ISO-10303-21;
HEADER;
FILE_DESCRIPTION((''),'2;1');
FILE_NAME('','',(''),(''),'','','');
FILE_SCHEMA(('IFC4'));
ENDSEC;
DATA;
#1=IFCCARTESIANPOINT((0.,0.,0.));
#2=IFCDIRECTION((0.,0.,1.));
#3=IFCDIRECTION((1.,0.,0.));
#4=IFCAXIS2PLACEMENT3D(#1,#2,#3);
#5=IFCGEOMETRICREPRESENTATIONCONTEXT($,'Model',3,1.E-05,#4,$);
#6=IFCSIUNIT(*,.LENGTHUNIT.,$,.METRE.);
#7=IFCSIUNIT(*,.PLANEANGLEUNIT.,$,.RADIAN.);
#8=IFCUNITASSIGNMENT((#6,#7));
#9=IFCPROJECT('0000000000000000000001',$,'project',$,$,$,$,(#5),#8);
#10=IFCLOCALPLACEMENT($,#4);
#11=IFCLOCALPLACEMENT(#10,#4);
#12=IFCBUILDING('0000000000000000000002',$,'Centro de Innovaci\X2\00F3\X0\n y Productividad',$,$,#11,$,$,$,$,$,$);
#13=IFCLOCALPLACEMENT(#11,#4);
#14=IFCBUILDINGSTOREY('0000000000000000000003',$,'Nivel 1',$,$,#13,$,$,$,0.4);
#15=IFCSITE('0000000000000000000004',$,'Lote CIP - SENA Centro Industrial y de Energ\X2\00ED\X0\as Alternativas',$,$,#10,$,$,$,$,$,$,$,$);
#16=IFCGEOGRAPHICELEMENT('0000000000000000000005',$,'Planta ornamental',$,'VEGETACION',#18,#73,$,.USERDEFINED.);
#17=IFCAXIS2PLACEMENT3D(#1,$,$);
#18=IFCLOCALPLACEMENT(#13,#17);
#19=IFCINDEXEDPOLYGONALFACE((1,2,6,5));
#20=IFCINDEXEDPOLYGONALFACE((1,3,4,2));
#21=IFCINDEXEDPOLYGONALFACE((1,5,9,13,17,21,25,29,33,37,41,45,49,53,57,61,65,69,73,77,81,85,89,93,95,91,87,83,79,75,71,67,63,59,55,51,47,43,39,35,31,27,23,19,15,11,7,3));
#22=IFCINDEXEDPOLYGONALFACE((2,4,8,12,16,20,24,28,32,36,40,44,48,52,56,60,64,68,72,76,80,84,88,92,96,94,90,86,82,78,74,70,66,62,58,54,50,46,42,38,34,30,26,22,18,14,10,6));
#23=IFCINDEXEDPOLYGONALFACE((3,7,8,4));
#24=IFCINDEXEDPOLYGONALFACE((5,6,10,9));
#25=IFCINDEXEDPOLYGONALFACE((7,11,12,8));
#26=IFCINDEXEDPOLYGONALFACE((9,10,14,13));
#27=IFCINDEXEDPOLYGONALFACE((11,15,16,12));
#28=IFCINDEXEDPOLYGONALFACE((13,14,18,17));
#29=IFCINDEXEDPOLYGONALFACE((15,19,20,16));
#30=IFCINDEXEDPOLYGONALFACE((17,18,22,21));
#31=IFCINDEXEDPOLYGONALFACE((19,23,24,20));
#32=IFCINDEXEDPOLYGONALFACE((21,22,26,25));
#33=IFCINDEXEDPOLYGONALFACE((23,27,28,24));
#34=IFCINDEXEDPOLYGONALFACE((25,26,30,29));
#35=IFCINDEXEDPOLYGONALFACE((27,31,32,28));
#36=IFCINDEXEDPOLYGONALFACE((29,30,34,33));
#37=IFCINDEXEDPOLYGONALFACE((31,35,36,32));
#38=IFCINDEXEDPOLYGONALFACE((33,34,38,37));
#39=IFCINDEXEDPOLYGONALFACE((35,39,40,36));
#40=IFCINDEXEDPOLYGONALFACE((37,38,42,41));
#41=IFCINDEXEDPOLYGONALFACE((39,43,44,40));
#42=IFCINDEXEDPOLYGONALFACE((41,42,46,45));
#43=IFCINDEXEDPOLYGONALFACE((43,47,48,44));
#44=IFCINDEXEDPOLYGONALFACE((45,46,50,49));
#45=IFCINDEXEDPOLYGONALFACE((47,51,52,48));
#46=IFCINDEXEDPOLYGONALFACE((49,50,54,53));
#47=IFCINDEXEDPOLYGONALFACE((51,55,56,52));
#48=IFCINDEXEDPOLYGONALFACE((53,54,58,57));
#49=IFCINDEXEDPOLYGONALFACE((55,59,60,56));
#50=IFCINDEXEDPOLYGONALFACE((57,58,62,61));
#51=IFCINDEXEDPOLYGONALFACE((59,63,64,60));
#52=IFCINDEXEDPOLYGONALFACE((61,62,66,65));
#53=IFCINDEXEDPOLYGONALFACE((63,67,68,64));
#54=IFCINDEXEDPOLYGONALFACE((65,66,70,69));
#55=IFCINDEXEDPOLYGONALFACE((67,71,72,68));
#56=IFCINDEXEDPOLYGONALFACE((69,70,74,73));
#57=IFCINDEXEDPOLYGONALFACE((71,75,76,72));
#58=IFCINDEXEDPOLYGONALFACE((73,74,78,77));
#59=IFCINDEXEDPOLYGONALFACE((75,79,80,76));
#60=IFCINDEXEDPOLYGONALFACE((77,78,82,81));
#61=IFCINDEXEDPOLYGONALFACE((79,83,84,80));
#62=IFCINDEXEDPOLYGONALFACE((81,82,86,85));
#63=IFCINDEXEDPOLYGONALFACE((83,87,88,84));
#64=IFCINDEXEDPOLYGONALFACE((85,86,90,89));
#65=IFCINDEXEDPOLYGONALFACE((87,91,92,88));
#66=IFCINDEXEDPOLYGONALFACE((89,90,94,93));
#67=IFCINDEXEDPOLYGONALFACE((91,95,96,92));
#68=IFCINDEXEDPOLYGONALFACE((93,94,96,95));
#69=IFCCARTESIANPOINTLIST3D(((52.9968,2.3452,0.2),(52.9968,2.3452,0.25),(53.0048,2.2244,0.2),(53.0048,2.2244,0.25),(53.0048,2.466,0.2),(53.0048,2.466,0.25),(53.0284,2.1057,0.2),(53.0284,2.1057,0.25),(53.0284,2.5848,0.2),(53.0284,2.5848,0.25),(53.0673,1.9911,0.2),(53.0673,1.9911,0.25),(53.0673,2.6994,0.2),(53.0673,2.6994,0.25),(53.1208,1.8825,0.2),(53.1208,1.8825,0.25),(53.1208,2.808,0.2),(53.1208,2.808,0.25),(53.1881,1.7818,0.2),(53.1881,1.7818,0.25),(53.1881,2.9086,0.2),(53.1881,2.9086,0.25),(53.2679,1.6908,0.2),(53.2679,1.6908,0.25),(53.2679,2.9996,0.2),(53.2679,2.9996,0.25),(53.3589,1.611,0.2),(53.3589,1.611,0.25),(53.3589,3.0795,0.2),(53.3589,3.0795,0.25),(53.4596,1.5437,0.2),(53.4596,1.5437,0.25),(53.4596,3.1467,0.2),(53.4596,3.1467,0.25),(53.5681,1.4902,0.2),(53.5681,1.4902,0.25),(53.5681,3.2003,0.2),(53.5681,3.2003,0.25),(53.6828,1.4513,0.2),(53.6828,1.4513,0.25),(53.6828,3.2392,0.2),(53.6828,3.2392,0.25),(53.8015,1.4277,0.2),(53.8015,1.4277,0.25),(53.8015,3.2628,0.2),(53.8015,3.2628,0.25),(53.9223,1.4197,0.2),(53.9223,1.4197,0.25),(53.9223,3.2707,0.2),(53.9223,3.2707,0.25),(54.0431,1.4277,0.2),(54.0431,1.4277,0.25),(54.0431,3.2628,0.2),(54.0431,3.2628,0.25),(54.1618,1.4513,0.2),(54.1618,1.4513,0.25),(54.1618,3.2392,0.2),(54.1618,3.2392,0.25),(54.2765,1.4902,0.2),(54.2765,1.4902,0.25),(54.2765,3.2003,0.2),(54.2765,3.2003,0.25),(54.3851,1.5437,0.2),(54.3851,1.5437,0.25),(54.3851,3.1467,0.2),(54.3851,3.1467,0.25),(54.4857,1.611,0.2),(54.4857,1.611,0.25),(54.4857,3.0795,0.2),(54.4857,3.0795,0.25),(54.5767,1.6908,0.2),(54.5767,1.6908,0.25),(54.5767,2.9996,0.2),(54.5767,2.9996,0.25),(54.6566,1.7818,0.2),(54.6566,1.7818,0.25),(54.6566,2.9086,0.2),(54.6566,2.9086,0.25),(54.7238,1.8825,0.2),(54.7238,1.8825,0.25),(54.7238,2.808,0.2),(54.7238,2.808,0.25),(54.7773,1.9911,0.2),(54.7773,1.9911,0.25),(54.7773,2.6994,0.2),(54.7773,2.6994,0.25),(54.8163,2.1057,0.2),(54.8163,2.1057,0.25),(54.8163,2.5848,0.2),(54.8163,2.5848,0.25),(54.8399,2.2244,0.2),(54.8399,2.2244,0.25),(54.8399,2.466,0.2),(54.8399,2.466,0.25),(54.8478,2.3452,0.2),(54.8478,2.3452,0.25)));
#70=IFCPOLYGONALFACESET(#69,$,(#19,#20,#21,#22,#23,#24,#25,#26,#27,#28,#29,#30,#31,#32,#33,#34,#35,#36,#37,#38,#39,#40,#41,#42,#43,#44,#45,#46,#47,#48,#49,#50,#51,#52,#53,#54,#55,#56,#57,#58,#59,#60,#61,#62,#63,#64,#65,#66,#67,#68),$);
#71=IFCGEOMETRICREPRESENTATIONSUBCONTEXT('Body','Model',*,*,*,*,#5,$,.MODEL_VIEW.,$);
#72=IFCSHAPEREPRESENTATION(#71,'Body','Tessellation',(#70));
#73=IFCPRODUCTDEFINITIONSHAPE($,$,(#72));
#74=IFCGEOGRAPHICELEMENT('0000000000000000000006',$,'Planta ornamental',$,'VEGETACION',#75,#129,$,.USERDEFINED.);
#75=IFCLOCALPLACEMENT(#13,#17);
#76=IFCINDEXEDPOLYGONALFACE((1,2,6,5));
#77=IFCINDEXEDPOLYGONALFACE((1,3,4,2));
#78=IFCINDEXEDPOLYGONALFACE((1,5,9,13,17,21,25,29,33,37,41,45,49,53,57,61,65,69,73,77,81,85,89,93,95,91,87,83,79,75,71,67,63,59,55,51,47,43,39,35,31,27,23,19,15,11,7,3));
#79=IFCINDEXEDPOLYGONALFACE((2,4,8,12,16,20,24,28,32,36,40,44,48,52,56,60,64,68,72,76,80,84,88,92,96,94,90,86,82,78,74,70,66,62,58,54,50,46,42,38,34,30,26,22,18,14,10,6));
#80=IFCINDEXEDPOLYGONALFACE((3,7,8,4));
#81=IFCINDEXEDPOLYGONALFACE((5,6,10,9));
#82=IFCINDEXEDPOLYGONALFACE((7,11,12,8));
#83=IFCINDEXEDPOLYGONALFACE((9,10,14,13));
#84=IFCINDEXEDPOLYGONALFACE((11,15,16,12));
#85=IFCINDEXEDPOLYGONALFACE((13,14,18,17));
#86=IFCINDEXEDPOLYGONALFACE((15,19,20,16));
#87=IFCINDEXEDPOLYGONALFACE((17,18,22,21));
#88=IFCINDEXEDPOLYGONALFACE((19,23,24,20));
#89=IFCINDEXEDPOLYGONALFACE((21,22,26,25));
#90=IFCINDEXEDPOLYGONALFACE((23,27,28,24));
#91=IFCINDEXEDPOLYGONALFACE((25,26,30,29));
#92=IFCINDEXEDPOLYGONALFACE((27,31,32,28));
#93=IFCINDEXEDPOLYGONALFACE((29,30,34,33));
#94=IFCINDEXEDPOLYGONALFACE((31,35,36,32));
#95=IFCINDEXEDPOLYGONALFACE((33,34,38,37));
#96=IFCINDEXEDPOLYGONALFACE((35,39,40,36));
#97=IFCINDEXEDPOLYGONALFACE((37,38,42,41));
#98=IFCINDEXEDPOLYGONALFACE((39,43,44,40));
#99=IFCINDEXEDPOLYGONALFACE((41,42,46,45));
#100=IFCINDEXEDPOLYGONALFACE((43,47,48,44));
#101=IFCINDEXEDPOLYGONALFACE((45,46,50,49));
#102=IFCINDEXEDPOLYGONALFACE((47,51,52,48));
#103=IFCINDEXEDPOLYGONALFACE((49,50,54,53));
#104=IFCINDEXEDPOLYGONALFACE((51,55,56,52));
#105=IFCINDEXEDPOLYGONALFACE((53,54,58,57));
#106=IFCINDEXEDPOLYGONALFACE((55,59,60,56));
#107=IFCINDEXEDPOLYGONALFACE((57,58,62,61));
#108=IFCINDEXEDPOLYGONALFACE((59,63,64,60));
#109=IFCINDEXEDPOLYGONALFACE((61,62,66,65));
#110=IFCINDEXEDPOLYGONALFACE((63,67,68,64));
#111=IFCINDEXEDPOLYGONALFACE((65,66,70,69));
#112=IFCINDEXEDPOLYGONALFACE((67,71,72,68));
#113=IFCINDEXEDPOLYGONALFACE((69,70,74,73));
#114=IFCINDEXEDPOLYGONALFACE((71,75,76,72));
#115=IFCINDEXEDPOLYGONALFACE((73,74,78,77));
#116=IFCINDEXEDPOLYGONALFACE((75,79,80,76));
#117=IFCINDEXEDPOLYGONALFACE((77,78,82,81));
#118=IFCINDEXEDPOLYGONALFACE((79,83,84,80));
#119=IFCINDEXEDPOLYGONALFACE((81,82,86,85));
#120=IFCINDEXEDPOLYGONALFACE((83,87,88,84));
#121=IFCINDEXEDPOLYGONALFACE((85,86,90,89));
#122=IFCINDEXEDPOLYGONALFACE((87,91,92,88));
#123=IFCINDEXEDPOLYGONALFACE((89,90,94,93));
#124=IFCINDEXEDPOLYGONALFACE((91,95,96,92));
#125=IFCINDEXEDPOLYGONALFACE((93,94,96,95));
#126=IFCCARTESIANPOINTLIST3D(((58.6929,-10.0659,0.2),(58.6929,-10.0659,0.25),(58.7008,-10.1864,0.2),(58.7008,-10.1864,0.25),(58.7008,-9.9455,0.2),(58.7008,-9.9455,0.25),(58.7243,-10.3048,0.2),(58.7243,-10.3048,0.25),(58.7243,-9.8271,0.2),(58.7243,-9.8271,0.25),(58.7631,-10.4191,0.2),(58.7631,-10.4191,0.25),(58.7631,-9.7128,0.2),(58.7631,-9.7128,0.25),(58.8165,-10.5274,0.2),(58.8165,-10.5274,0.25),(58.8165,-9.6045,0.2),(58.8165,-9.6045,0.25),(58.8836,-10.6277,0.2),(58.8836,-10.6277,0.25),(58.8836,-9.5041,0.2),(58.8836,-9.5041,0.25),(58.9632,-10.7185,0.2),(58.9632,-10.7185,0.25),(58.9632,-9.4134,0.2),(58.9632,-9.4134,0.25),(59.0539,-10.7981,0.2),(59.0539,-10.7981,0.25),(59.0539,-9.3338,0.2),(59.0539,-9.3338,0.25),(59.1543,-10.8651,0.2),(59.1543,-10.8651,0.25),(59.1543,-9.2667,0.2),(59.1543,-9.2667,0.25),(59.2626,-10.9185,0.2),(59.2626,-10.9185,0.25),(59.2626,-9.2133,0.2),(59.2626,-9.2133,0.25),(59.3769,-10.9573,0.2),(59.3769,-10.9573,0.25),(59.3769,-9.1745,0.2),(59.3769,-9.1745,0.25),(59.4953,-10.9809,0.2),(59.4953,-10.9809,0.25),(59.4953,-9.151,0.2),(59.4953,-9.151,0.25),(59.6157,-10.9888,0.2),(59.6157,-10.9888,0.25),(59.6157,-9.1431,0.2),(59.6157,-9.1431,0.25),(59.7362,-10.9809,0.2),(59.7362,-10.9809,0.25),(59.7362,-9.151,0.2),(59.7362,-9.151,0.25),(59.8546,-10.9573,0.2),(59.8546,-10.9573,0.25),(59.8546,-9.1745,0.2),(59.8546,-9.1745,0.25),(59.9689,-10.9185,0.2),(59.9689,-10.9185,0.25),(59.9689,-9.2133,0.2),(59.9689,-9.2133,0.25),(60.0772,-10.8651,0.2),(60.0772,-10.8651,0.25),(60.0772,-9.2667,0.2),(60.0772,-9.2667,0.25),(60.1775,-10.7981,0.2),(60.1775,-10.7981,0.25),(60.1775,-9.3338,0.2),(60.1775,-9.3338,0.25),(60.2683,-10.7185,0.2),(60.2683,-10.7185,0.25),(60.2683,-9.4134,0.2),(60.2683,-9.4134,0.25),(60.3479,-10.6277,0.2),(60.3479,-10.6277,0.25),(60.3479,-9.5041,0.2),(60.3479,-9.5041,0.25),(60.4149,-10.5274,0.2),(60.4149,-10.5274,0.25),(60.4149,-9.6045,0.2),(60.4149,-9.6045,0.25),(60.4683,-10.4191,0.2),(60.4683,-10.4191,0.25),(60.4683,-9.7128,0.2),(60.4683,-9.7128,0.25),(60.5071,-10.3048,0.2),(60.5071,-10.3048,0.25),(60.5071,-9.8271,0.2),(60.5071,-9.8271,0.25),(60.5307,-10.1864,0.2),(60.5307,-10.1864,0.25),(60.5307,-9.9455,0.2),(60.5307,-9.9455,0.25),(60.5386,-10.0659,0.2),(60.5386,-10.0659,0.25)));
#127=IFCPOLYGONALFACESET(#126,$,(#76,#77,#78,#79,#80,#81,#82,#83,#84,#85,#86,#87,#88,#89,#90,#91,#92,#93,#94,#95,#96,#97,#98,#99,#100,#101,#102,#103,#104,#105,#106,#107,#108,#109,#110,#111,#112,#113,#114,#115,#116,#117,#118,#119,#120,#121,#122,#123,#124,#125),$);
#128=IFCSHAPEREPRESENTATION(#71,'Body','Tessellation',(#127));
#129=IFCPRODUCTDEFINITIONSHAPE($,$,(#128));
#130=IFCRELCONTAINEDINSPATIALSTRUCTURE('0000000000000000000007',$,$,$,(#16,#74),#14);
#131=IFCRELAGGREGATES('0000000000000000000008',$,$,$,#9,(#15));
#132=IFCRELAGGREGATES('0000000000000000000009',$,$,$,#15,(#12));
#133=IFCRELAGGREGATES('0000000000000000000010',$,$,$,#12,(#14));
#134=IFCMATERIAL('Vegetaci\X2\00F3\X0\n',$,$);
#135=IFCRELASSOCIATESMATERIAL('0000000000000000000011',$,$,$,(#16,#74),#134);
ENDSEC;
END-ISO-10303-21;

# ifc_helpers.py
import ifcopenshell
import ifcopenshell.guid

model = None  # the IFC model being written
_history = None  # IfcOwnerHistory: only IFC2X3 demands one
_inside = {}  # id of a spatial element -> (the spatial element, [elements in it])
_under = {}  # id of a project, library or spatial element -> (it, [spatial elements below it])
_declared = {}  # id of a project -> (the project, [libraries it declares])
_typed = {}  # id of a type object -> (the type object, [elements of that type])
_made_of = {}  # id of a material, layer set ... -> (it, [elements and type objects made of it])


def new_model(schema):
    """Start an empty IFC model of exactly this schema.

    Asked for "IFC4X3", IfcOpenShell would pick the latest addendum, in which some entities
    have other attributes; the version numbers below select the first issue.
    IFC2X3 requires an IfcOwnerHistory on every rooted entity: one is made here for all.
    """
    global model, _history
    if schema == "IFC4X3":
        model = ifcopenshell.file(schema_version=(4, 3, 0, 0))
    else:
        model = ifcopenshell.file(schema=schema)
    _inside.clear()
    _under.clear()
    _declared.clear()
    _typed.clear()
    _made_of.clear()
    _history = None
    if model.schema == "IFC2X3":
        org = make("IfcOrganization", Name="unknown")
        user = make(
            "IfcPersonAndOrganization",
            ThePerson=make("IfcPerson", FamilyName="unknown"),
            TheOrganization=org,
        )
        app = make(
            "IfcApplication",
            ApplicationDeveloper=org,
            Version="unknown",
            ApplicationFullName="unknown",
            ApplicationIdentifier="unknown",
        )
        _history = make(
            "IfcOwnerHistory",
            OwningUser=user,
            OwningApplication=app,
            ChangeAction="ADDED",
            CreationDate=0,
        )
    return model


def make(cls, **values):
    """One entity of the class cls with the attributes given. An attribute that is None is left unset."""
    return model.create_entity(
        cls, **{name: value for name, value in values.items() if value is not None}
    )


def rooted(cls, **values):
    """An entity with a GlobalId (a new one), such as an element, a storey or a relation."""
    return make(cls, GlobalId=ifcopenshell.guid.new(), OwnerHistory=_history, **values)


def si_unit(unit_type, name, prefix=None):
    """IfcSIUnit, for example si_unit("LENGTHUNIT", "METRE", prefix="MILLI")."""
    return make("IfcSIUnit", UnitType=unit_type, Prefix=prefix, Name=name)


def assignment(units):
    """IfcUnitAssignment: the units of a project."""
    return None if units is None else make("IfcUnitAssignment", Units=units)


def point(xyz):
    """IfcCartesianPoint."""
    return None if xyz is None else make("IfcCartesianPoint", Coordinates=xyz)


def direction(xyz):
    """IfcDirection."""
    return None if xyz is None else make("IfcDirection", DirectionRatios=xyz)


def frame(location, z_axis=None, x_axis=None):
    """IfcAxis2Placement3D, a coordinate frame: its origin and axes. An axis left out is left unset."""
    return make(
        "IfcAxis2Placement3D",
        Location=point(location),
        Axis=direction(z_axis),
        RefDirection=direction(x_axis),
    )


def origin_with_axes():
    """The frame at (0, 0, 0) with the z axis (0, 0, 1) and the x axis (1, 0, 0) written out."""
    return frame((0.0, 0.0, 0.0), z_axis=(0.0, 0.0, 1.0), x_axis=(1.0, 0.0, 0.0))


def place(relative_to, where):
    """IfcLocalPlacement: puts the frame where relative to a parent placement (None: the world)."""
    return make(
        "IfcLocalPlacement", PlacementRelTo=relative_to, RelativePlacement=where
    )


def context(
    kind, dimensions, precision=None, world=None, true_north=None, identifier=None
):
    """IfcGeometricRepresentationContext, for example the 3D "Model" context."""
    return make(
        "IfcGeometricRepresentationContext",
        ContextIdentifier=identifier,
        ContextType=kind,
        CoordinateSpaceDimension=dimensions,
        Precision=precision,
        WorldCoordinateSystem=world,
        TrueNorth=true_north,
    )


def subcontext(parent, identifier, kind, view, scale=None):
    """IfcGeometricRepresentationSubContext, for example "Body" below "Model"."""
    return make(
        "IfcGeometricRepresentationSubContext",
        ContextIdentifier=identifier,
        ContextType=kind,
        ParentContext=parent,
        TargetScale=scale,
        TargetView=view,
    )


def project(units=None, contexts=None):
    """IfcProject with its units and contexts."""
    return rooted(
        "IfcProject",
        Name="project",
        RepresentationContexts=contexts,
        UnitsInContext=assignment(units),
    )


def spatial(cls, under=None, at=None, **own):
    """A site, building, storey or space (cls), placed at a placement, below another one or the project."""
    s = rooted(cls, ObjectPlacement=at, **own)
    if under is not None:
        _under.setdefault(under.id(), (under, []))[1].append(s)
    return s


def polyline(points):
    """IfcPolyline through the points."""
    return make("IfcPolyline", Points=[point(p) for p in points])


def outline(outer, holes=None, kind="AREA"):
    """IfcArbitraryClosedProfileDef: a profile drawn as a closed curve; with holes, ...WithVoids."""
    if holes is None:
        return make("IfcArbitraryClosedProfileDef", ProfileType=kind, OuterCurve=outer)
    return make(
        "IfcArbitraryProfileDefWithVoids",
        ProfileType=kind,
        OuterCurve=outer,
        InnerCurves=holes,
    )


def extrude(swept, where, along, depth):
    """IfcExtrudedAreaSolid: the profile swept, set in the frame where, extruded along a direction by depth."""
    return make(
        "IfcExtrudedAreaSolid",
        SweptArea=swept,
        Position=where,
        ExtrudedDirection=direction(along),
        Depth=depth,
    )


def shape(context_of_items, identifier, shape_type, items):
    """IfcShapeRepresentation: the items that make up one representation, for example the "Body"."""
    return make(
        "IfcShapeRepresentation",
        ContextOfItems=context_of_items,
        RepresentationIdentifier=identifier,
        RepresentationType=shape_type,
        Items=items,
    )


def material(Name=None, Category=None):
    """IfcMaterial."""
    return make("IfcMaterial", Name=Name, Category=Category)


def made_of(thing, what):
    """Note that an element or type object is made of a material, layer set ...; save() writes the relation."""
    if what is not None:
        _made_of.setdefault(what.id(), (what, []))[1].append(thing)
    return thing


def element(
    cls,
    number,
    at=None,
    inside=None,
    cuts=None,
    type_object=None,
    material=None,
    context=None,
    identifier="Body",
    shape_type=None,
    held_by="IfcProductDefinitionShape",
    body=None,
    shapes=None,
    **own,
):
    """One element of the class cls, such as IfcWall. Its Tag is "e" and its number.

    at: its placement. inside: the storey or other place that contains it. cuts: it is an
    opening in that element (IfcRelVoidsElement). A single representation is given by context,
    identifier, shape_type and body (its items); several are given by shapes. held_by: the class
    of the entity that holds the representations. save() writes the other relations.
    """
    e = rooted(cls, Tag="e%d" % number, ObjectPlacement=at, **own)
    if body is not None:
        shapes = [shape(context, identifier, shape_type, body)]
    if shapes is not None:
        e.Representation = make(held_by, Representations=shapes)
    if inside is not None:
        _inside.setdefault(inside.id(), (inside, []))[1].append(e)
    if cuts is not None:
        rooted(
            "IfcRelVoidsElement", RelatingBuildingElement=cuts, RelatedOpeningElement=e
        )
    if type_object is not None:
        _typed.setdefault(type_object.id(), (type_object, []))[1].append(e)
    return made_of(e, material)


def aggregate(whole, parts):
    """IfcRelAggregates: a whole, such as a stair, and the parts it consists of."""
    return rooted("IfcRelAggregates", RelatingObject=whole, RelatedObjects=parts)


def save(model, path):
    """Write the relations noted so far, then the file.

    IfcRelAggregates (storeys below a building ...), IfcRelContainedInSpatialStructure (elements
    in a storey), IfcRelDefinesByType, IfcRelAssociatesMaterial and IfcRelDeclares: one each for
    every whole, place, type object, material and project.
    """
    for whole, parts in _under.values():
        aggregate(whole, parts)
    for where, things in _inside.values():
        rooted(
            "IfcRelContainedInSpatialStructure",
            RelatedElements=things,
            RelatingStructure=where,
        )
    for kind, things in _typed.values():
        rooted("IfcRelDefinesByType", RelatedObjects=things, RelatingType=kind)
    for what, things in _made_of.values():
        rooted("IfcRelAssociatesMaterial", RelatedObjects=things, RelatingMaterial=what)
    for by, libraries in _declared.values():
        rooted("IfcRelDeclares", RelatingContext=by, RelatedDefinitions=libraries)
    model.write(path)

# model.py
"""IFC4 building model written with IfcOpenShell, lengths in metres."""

from ifc_helpers import new_model, si_unit, frame, origin_with_axes, place, context, subcontext, project, spatial, polyline, outline, extrude, material, element, save


model = new_model("IFC4")

# Units and contexts
model_context = context("Model", 3, precision=1e-05, world=origin_with_axes())
body_context = subcontext(model_context, "Body", "Model", "MODEL_VIEW")
ifc_project = project(units=[si_unit("LENGTHUNIT", "METRE"), si_unit("PLANEANGLEUNIT", "RADIAN")], contexts=[model_context])

# Site, building, storey
site_placement = place(None, origin_with_axes())
site = spatial("IfcSite", under=ifc_project, at=site_placement, Name="Lote CIP - SENA Centro Industrial y de Energías Alternativas")
building_placement = place(site_placement, origin_with_axes())
building = spatial("IfcBuilding", under=site, at=building_placement, Name="Centro de Innovación y Productividad")
storey_placement = place(building_placement, origin_with_axes())
storey = spatial("IfcBuildingStorey", under=building, at=storey_placement, Name="Nivel 1", Elevation=0.4)

# Geographic elements
ifc_material = material(Name="Vegetación")
geographic_element_1_placement = place(storey_placement, origin_with_axes())
element("IfcGeographicElement", 1, at=geographic_element_1_placement, inside=storey, material=ifc_material, Name="Planta ornamental", ObjectType="VEGETACION", PredefinedType="USERDEFINED", context=body_context, shape_type="SweptSolid", body=[
    extrude(outline(polyline([(54.8478, 2.3452), (54.8399, 2.2244), (54.8163, 2.1057), (54.7773, 1.9911), (54.7238, 1.8825), (54.6566, 1.7818), (54.5767, 1.6908), (54.4857, 1.611), (54.3851, 1.5437), (54.2765, 1.4902), (54.1618, 1.4513), (54.0431, 1.4277), (53.9223, 1.4197), (53.8015, 1.4277), (53.6828, 1.4513), (53.5681, 1.4902), (53.4596, 1.5437), (53.3589, 1.611), (53.2679, 1.6908), (53.1881, 1.7818), (53.1208, 1.8825), (53.0673, 1.9911), (53.0284, 2.1057), (53.0048, 2.2244), (52.9968, 2.3452), (53.0048, 2.466), (53.0284, 2.5848), (53.0673, 2.6994), (53.1208, 2.808), (53.1881, 2.9086), (53.2679, 2.9996), (53.3589, 3.0795), (53.4596, 3.1467), (53.5681, 3.2003), (53.6828, 3.2392), (53.8015, 3.2628), (53.9223, 3.2707), (54.0431, 3.2628), (54.1618, 3.2392), (54.2765, 3.2003), (54.3851, 3.1467), (54.4857, 3.0795), (54.5767, 2.9996), (54.6566, 2.9086), (54.7238, 2.808), (54.7773, 2.6994), (54.8163, 2.5848), (54.8399, 2.466), (54.8478, 2.3452)])), frame((0.0, 0.0, 0.2)), (0.0, 0.0, 1.0), 0.05),
])
geographic_element_2_placement = place(storey_placement, origin_with_axes())
element("IfcGeographicElement", 2, at=geographic_element_2_placement, inside=storey, material=ifc_material, Name="Planta ornamental", ObjectType="VEGETACION", PredefinedType="USERDEFINED", context=body_context, shape_type="SweptSolid", body=[
    extrude(outline(polyline([(60.5386, -10.0659), (60.5307, -10.1864), (60.5071, -10.3048), (60.4683, -10.4191), (60.4149, -10.5274), (60.3479, -10.6277), (60.2683, -10.7185), (60.1775, -10.7981), (60.0772, -10.8651), (59.9689, -10.9185), (59.8546, -10.9573), (59.7362, -10.9809), (59.6157, -10.9888), (59.4953, -10.9809), (59.3769, -10.9573), (59.2626, -10.9185), (59.1543, -10.8651), (59.0539, -10.7981), (58.9632, -10.7185), (58.8836, -10.6277), (58.8165, -10.5274), (58.7631, -10.4191), (58.7243, -10.3048), (58.7008, -10.1864), (58.6929, -10.0659), (58.7008, -9.9455), (58.7243, -9.8271), (58.7631, -9.7128), (58.8165, -9.6045), (58.8836, -9.5041), (58.9632, -9.4134), (59.0539, -9.3338), (59.1543, -9.2667), (59.2626, -9.2133), (59.3769, -9.1745), (59.4953, -9.151), (59.6157, -9.1431), (59.7362, -9.151), (59.8546, -9.1745), (59.9689, -9.2133), (60.0772, -9.2667), (60.1775, -9.3338), (60.2683, -9.4134), (60.3479, -9.5041), (60.4149, -9.6045), (60.4683, -9.7128), (60.5071, -9.8271), (60.5307, -9.9455), (60.5386, -10.0659)])), frame((0.0, 0.0, 0.2)), (0.0, 0.0, 1.0), 0.05),
])

save(model, "model.ifc")
